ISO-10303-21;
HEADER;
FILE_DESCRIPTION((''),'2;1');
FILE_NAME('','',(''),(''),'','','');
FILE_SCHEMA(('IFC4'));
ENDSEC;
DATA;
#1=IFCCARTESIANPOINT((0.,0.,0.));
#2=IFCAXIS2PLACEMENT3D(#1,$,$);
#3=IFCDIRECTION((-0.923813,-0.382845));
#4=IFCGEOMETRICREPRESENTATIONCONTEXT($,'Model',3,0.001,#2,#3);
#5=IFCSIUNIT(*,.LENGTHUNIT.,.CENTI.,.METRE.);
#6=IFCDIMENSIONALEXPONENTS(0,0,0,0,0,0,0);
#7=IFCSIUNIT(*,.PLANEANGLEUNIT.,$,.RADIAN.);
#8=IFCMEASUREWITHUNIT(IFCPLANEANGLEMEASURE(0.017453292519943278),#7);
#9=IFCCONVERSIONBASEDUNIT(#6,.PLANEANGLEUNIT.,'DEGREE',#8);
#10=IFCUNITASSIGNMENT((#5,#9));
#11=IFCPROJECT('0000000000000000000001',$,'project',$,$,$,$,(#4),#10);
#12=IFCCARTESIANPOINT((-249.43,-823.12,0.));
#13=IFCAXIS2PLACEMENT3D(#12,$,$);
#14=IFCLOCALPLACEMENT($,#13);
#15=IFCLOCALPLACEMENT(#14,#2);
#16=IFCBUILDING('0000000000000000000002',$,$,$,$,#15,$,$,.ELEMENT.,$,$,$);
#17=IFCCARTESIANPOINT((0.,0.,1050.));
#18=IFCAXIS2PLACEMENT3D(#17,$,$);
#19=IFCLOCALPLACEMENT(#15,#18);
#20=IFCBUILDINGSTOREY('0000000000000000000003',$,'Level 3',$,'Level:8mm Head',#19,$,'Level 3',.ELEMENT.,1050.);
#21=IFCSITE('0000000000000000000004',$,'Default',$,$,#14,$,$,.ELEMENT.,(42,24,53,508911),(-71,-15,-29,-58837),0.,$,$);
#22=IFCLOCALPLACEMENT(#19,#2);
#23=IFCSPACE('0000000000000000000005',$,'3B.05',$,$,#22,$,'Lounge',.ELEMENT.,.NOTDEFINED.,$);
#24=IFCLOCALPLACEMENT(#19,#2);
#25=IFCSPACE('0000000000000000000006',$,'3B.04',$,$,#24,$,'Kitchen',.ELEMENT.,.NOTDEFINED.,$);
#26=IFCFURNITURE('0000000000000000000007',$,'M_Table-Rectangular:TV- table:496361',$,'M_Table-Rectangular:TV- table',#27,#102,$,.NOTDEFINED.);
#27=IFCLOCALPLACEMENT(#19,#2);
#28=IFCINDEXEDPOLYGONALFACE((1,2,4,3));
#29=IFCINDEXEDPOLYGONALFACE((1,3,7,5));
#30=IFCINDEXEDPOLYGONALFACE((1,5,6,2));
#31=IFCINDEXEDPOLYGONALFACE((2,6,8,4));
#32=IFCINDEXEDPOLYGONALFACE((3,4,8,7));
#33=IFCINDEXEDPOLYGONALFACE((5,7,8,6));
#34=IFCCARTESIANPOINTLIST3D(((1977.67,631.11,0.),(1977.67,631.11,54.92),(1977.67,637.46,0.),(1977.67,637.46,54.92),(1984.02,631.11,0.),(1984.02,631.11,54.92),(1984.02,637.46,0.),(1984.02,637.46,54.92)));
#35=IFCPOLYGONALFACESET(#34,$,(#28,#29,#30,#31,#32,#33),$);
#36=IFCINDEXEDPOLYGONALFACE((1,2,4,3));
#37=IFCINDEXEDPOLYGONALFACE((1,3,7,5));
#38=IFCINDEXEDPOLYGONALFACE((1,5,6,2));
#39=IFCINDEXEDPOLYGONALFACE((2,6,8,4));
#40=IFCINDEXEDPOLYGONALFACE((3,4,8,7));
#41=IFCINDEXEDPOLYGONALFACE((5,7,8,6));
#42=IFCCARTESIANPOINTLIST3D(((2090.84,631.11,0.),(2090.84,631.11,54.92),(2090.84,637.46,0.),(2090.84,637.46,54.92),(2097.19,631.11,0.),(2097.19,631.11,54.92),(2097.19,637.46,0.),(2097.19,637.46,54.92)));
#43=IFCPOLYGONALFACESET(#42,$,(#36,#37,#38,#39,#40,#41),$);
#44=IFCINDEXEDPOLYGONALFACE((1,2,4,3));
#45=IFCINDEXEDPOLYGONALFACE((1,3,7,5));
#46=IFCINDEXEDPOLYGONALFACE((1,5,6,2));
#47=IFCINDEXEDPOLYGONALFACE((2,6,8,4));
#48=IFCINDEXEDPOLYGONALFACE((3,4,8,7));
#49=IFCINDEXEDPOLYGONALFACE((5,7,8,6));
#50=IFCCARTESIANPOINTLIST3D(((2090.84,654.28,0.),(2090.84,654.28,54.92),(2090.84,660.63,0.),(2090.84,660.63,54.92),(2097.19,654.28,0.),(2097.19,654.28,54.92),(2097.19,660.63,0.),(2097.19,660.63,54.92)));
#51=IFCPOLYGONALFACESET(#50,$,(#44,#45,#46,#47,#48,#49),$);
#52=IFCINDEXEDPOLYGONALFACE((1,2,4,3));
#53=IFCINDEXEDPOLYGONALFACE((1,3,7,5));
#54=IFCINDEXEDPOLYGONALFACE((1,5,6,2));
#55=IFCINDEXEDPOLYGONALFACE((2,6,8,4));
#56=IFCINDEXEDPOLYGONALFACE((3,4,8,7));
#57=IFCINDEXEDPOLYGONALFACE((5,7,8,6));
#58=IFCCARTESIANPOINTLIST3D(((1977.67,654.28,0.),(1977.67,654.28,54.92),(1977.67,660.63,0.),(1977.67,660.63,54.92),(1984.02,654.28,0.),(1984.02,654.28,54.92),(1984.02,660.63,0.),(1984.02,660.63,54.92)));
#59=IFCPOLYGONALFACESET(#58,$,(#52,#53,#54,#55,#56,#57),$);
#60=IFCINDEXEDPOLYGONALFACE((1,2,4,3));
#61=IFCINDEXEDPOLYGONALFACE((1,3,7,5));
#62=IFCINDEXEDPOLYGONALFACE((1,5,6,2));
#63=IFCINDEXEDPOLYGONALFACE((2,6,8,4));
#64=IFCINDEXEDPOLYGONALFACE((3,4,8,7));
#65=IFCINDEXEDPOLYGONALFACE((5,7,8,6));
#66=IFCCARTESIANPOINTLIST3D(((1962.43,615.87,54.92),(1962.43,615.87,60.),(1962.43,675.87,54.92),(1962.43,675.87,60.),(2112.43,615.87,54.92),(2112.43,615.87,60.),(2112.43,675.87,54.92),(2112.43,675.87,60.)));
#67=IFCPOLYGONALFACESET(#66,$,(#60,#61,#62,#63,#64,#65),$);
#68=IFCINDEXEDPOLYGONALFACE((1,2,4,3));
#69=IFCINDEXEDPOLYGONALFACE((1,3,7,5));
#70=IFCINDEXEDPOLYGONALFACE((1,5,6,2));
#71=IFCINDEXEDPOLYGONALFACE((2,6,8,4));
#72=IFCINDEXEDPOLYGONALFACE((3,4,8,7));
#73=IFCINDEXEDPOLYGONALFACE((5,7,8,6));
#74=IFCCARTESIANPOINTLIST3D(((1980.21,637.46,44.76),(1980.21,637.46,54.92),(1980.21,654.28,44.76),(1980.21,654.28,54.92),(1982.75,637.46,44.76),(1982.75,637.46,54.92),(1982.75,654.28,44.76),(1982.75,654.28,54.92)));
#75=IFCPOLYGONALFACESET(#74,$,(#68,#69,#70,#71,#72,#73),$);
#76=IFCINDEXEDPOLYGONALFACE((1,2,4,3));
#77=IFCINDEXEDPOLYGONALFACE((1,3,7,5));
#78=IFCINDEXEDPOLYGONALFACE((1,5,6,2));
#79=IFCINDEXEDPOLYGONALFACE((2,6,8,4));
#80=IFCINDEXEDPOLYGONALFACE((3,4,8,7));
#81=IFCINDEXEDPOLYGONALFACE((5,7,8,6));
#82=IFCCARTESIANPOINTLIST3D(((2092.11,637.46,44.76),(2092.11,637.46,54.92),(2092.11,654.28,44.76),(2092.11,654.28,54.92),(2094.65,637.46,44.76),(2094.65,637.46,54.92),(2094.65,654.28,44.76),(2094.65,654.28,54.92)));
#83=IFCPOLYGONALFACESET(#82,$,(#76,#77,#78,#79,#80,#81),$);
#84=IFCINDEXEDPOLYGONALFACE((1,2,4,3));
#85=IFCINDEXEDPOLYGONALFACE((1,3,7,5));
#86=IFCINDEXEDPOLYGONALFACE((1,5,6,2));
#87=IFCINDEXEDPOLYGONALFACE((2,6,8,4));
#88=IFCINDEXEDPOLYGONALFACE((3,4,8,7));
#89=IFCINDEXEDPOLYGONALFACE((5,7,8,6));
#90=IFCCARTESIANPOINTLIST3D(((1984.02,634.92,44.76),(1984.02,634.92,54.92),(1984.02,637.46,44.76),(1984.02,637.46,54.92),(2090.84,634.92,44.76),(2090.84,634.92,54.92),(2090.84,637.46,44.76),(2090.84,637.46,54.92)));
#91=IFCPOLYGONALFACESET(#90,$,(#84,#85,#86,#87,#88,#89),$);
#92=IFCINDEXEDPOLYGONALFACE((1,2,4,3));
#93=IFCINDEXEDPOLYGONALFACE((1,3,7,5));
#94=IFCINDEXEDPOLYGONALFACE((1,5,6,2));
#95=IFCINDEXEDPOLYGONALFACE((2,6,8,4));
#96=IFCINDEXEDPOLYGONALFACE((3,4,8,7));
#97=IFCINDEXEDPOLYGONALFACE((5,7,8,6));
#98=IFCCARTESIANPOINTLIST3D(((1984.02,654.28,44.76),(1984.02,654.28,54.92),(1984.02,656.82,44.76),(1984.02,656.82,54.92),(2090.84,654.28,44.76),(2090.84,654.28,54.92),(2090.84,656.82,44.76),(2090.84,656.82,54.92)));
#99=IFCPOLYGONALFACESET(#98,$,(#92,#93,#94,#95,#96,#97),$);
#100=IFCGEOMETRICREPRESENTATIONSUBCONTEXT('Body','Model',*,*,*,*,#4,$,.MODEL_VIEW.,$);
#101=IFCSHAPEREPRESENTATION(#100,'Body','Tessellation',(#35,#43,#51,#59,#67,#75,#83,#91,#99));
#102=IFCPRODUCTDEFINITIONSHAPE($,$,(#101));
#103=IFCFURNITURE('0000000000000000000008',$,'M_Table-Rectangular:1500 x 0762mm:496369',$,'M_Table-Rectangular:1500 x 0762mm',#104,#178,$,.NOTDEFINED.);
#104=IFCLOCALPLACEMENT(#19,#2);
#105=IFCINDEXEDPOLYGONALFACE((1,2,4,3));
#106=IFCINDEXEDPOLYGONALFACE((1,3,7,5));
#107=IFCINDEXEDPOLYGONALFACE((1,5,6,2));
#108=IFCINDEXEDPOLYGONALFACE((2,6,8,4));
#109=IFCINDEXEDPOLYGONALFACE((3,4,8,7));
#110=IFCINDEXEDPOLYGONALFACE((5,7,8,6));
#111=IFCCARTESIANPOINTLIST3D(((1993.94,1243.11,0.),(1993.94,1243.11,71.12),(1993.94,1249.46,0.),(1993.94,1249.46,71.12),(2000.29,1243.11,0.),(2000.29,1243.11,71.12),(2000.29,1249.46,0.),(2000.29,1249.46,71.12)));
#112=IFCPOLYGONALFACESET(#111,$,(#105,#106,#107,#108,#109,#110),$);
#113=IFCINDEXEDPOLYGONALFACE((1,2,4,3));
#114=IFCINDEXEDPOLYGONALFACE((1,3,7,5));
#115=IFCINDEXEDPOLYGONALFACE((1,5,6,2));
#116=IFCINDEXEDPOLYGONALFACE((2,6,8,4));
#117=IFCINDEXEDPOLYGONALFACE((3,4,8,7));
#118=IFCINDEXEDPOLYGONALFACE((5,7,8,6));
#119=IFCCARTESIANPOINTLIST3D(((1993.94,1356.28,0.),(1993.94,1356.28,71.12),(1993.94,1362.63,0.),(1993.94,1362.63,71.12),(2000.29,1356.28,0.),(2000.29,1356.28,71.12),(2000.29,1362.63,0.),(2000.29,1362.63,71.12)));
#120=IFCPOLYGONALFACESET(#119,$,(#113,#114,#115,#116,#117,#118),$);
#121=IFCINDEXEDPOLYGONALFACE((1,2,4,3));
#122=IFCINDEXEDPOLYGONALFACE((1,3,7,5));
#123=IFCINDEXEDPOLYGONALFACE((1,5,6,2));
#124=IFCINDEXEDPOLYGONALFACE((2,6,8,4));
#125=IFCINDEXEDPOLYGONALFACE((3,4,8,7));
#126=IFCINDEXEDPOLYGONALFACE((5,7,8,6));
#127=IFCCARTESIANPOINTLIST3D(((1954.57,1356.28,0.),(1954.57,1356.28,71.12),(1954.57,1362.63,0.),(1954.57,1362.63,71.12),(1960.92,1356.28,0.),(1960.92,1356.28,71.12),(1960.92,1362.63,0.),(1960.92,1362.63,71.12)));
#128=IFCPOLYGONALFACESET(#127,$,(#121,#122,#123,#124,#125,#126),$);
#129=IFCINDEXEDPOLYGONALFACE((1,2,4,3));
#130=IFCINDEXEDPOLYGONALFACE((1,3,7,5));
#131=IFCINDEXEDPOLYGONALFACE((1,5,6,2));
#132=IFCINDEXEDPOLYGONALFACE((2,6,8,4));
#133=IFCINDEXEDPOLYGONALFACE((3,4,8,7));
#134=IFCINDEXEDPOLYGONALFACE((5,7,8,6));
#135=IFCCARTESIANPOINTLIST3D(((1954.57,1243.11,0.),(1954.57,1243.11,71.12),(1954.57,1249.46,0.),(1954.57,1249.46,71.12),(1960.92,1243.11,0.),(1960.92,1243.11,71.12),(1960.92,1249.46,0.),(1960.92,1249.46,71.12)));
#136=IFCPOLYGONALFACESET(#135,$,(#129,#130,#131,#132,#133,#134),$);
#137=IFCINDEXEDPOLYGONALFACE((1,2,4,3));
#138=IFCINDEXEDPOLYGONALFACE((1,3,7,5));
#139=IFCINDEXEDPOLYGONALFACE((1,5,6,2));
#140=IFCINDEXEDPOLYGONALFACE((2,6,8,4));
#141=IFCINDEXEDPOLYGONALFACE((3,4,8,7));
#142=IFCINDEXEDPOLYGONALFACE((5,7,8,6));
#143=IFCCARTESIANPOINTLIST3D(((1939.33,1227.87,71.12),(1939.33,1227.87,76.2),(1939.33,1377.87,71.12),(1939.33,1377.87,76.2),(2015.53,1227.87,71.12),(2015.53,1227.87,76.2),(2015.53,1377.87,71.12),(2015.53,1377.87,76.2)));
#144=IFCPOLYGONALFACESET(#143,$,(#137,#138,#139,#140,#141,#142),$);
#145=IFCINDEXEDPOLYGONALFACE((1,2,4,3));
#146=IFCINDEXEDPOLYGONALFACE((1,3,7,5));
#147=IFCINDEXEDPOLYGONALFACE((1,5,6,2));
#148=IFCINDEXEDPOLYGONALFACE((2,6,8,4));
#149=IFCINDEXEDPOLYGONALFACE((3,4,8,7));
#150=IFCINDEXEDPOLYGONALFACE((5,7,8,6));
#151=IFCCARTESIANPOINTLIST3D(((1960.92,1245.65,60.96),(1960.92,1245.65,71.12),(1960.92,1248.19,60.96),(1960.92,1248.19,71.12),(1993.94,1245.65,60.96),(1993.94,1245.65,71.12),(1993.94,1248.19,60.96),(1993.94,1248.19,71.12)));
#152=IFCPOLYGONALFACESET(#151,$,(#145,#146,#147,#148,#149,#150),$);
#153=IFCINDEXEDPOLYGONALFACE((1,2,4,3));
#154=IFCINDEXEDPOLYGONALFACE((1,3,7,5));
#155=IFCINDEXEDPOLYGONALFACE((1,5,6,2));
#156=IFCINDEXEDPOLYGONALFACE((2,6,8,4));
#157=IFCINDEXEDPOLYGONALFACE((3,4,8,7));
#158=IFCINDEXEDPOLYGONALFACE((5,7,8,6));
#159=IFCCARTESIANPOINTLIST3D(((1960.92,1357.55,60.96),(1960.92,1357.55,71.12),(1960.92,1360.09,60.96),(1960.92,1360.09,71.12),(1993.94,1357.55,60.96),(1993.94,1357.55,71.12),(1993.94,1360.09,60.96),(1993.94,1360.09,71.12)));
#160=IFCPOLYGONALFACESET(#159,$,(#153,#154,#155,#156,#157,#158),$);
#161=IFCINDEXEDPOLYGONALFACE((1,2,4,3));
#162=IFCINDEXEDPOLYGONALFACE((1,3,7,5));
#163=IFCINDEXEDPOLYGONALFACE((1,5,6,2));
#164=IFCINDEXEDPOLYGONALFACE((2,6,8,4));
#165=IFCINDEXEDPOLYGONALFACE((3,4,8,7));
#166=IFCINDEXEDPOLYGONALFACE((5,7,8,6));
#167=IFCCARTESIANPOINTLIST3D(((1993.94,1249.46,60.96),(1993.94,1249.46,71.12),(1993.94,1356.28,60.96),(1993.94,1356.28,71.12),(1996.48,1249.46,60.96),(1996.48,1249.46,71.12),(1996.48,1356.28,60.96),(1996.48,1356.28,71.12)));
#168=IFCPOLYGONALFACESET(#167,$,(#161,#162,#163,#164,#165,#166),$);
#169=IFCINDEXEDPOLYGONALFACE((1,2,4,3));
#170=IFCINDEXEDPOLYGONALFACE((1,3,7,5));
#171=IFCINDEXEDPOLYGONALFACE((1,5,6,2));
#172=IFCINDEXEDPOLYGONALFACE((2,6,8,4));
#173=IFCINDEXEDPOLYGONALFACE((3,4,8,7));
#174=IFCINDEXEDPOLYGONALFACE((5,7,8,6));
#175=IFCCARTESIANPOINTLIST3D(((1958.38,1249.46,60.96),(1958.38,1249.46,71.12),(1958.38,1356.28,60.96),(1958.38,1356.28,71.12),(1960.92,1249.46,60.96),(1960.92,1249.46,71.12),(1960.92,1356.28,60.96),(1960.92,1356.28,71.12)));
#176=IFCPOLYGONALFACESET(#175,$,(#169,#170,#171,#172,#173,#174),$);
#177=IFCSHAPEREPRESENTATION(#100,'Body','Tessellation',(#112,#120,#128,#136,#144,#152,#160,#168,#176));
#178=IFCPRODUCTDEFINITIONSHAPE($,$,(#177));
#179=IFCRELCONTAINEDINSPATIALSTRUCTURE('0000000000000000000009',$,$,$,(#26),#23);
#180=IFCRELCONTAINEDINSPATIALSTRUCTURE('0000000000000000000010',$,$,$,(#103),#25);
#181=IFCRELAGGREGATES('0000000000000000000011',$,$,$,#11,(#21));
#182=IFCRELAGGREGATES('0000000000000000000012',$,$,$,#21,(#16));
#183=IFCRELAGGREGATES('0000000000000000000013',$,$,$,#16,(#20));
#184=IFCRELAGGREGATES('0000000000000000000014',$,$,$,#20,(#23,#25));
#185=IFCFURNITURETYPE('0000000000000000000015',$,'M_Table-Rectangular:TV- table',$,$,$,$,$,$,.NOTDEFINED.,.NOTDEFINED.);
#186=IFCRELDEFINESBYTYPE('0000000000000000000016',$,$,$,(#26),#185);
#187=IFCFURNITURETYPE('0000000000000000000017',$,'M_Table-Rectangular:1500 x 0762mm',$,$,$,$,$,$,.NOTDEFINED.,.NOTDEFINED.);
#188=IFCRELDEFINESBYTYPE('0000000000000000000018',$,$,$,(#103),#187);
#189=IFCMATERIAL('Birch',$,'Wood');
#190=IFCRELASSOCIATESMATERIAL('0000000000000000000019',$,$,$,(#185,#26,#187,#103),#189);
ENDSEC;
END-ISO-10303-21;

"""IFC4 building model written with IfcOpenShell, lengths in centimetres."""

from ifc_helpers import new_model, entity, si_unit, converted_unit, direction, frame, origin, place, context, subcontext, project, spatial, indexed_curve, outline, extrude, source, transform, mapped, material, type_object, type_shapes, element, save


model = new_model("IFC4")

# Units and contexts
model_context = context("Model", 3, precision=0.001, world=origin(), true_north=direction((-0.923813, -0.382845)))
body_context = subcontext(model_context, "Body", "Model", "MODEL_VIEW")
ifc_project = project(units=[si_unit("LENGTHUNIT", "METRE", prefix="CENTI"), converted_unit("PLANEANGLEUNIT", "DEGREE", entity("IfcPlaneAngleMeasure", 0.017453292519943278), si_unit("PLANEANGLEUNIT", "RADIAN"), dimensions=[0, 0, 0, 0, 0, 0, 0])], contexts=[model_context])

# Site, building, storey
site_placement = place(None, frame((-249.43, -823.12, 0.0)))
site = spatial("IfcSite", under=ifc_project, at=site_placement, Name="Default", CompositionType="ELEMENT", RefLatitude=(42, 24, 53, 508911), RefLongitude=(-71, -15, -29, -58837), RefElevation=0.0)
building_placement = place(site_placement, origin())
building = spatial("IfcBuilding", under=site, at=building_placement, CompositionType="ELEMENT")
storey_placement = place(building_placement, frame((0.0, 0.0, 1050.0)))
storey = spatial("IfcBuildingStorey", under=building, at=storey_placement, Name="Level 3", ObjectType="Level:8mm Head", LongName="Level 3", CompositionType="ELEMENT", Elevation=1050.0)

# Shared definitions
space_1_placement = place(storey_placement, origin())
space_1 = spatial("IfcSpace", under=storey, at=space_1_placement, Name="3B.05", LongName="Lounge", CompositionType="ELEMENT", PredefinedType="NOTDEFINED")

# Furniture
ifc_material_1 = material(Name="Birch", Category="Wood")
furniture_type_1 = type_object("IfcFurnitureType", Name="M_Table-Rectangular:TV- table", AssemblyPlace="NOTDEFINED", PredefinedType="NOTDEFINED", material=ifc_material_1)
shared_shape_1 = source(origin(), body_context, "Body", "SweptSolid", [
    extrude(outline(indexed_curve([(-3.18, -3.18), (3.18, -3.18), (3.18, 3.18), (-3.18, 3.18), (-3.18, -3.18)], self_intersect=False)), frame((56.58, 11.59, 0.0), z_axis=(0.0, 0.0, 1.0), x_axis=(0.0, -1.0, 0.0)), (0.0, 0.0, 1.0), 54.92),
    extrude(outline(indexed_curve([(-3.17, -3.18), (3.17, -3.18), (3.17, 3.18), (-3.17, 3.18), (-3.17, -3.18)], self_intersect=False)), frame((-56.58, 11.59, 0.0), z_axis=(0.0, 0.0, 1.0), x_axis=(-1.0, 0.0, 0.0)), (0.0, 0.0, 1.0), 54.92),
    extrude(outline(indexed_curve([(-3.17, -3.17), (3.17, -3.17), (3.17, 3.17), (-3.17, 3.17), (-3.17, -3.17)], self_intersect=False)), frame((-56.58, -11.59, 0.0), z_axis=(0.0, 0.0, 1.0), x_axis=(0.0, 1.0, 0.0)), (0.0, 0.0, 1.0), 54.92),
    extrude(outline(indexed_curve([(-3.18, -3.17), (3.18, -3.17), (3.18, 3.17), (-3.18, 3.17), (-3.18, -3.17)], self_intersect=False)), frame((56.58, -11.59, 0.0)), (0.0, 0.0, 1.0), 54.92),
    extrude(outline(indexed_curve([(-75.0, -30.0), (75.0, -30.0), (75.0, 30.0), (-75.0, 30.0), (-75.0, -30.0)], self_intersect=False)), frame((0.0, 0.0, 54.92), z_axis=(0.0, 0.0, 1.0), x_axis=(-1.0, 0.0, 0.0)), (0.0, 0.0, 1.0), 5.08),
    extrude(outline(indexed_curve([(-1.27, -8.41), (1.27, -8.41), (1.27, 8.41), (-1.27, 8.41), (-1.27, -8.41)], self_intersect=False)), frame((55.95, 0.0, 44.76)), (0.0, 0.0, 1.0), 10.16),
    extrude(outline(indexed_curve([(-8.41, -1.27), (8.41, -1.27), (8.41, 1.27), (-8.41, 1.27), (-8.41, -1.27)], self_intersect=False)), frame((-55.95, 0.0, 44.76), z_axis=(0.0, 0.0, 1.0), x_axis=(0.0, 1.0, 0.0)), (0.0, 0.0, 1.0), 10.16),
    extrude(outline(indexed_curve([(-53.41, -1.27), (53.41, -1.27), (53.41, 1.27), (-53.41, 1.27), (-53.41, -1.27)], self_intersect=False)), frame((0.0, 9.68, 44.76), z_axis=(0.0, 0.0, 1.0), x_axis=(-1.0, 0.0, 0.0)), (0.0, 0.0, 1.0), 10.16),
    extrude(outline(indexed_curve([(-1.27, -53.41), (1.27, -53.41), (1.27, 53.41), (-1.27, 53.41), (-1.27, -53.41)], self_intersect=False)), frame((0.0, -9.68, 44.76), z_axis=(0.0, 0.0, 1.0), x_axis=(0.0, 1.0, 0.0)), (0.0, 0.0, 1.0), 10.16),
])
type_shapes(furniture_type_1, [shared_shape_1])
furniture_1_placement = place(space_1_placement, frame((2037.43, 645.87, 0.0), z_axis=(0.0, 0.0, 1.0), x_axis=(-1.0, 0.0, 0.0)))
element("IfcFurniture", 1, at=furniture_1_placement, inside=space_1, type_object=furniture_type_1, material=ifc_material_1, Name="M_Table-Rectangular:TV- table:496361", ObjectType="M_Table-Rectangular:TV- table", PredefinedType="NOTDEFINED", context=body_context, shape_type="MappedRepresentation", body=[
    mapped(shared_shape_1, transform((0.0, 0.0, 0.0), scale=1.0)),
])

# Shared definitions
space_2_placement = place(storey_placement, origin())
space_2 = spatial("IfcSpace", under=storey, at=space_2_placement, Name="3B.04", LongName="Kitchen", CompositionType="ELEMENT", PredefinedType="NOTDEFINED")

# Furniture
furniture_type_2 = type_object("IfcFurnitureType", Name="M_Table-Rectangular:1500 x 0762mm", AssemblyPlace="NOTDEFINED", PredefinedType="NOTDEFINED", material=ifc_material_1)
shared_shape_2 = source(origin(), body_context, "Body", "SweptSolid", [
    extrude(outline(indexed_curve([(-3.18, -3.18), (3.18, -3.18), (3.18, 3.18), (-3.18, 3.18), (-3.18, -3.18)], self_intersect=False)), frame((56.58, 19.69, 0.0), z_axis=(0.0, 0.0, 1.0), x_axis=(0.0, -1.0, 0.0)), (0.0, 0.0, 1.0), 71.12),
    extrude(outline(indexed_curve([(-3.17, -3.18), (3.17, -3.18), (3.17, 3.18), (-3.17, 3.18), (-3.17, -3.18)], self_intersect=False)), frame((-56.58, 19.69, 0.0), z_axis=(0.0, 0.0, 1.0), x_axis=(-1.0, 0.0, 0.0)), (0.0, 0.0, 1.0), 71.12),
    extrude(outline(indexed_curve([(-3.17, -3.17), (3.17, -3.17), (3.17, 3.17), (-3.17, 3.17), (-3.17, -3.17)], self_intersect=False)), frame((-56.58, -19.69, 0.0), z_axis=(0.0, 0.0, 1.0), x_axis=(0.0, 1.0, 0.0)), (0.0, 0.0, 1.0), 71.12),
    extrude(outline(indexed_curve([(-3.18, -3.17), (3.18, -3.17), (3.18, 3.18), (-3.18, 3.18), (-3.18, -3.17)], self_intersect=False)), frame((56.58, -19.69, 0.0)), (0.0, 0.0, 1.0), 71.12),
    extrude(outline(indexed_curve([(-75.0, -38.1), (75.0, -38.1), (75.0, 38.1), (-75.0, 38.1), (-75.0, -38.1)], self_intersect=False)), frame((0.0, 0.0, 71.12), z_axis=(0.0, 0.0, 1.0), x_axis=(-1.0, 0.0, 0.0)), (0.0, 0.0, 1.0), 5.08),
    extrude(outline(indexed_curve([(-1.27, -16.51), (1.27, -16.51), (1.27, 16.51), (-1.27, 16.51), (-1.27, -16.51)], self_intersect=False)), frame((55.95, 0.0, 60.96)), (0.0, 0.0, 1.0), 10.16),
    extrude(outline(indexed_curve([(-16.51, -1.27), (16.51, -1.27), (16.51, 1.27), (-16.51, 1.27), (-16.51, -1.27)], self_intersect=False)), frame((-55.95, 0.0, 60.96), z_axis=(0.0, 0.0, 1.0), x_axis=(0.0, 1.0, 0.0)), (0.0, 0.0, 1.0), 10.16),
    extrude(outline(indexed_curve([(-53.41, -1.27), (53.41, -1.27), (53.41, 1.27), (-53.41, 1.27), (-53.41, -1.27)], self_intersect=False)), frame((0.0, 17.78, 60.96), z_axis=(0.0, 0.0, 1.0), x_axis=(-1.0, 0.0, 0.0)), (0.0, 0.0, 1.0), 10.16),
    extrude(outline(indexed_curve([(-1.27, -53.41), (1.27, -53.41), (1.27, 53.41), (-1.27, 53.41), (-1.27, -53.41)], self_intersect=False)), frame((0.0, -17.78, 60.96), z_axis=(0.0, 0.0, 1.0), x_axis=(0.0, 1.0, 0.0)), (0.0, 0.0, 1.0), 10.16),
])
type_shapes(furniture_type_2, [shared_shape_2])
furniture_2_placement = place(space_2_placement, frame((1977.43, 1302.87, 0.0), z_axis=(0.0, 0.0, 1.0), x_axis=(0.0, -1.0, 0.0)))
element("IfcFurniture", 2, at=furniture_2_placement, inside=space_2, type_object=furniture_type_2, material=ifc_material_1, Name="M_Table-Rectangular:1500 x 0762mm:496369", ObjectType="M_Table-Rectangular:1500 x 0762mm", PredefinedType="NOTDEFINED", context=body_context, shape_type="MappedRepresentation", body=[
    mapped(shared_shape_2, transform((0.0, 0.0, 0.0), scale=1.0)),
])

save(model, "model.ifc")
